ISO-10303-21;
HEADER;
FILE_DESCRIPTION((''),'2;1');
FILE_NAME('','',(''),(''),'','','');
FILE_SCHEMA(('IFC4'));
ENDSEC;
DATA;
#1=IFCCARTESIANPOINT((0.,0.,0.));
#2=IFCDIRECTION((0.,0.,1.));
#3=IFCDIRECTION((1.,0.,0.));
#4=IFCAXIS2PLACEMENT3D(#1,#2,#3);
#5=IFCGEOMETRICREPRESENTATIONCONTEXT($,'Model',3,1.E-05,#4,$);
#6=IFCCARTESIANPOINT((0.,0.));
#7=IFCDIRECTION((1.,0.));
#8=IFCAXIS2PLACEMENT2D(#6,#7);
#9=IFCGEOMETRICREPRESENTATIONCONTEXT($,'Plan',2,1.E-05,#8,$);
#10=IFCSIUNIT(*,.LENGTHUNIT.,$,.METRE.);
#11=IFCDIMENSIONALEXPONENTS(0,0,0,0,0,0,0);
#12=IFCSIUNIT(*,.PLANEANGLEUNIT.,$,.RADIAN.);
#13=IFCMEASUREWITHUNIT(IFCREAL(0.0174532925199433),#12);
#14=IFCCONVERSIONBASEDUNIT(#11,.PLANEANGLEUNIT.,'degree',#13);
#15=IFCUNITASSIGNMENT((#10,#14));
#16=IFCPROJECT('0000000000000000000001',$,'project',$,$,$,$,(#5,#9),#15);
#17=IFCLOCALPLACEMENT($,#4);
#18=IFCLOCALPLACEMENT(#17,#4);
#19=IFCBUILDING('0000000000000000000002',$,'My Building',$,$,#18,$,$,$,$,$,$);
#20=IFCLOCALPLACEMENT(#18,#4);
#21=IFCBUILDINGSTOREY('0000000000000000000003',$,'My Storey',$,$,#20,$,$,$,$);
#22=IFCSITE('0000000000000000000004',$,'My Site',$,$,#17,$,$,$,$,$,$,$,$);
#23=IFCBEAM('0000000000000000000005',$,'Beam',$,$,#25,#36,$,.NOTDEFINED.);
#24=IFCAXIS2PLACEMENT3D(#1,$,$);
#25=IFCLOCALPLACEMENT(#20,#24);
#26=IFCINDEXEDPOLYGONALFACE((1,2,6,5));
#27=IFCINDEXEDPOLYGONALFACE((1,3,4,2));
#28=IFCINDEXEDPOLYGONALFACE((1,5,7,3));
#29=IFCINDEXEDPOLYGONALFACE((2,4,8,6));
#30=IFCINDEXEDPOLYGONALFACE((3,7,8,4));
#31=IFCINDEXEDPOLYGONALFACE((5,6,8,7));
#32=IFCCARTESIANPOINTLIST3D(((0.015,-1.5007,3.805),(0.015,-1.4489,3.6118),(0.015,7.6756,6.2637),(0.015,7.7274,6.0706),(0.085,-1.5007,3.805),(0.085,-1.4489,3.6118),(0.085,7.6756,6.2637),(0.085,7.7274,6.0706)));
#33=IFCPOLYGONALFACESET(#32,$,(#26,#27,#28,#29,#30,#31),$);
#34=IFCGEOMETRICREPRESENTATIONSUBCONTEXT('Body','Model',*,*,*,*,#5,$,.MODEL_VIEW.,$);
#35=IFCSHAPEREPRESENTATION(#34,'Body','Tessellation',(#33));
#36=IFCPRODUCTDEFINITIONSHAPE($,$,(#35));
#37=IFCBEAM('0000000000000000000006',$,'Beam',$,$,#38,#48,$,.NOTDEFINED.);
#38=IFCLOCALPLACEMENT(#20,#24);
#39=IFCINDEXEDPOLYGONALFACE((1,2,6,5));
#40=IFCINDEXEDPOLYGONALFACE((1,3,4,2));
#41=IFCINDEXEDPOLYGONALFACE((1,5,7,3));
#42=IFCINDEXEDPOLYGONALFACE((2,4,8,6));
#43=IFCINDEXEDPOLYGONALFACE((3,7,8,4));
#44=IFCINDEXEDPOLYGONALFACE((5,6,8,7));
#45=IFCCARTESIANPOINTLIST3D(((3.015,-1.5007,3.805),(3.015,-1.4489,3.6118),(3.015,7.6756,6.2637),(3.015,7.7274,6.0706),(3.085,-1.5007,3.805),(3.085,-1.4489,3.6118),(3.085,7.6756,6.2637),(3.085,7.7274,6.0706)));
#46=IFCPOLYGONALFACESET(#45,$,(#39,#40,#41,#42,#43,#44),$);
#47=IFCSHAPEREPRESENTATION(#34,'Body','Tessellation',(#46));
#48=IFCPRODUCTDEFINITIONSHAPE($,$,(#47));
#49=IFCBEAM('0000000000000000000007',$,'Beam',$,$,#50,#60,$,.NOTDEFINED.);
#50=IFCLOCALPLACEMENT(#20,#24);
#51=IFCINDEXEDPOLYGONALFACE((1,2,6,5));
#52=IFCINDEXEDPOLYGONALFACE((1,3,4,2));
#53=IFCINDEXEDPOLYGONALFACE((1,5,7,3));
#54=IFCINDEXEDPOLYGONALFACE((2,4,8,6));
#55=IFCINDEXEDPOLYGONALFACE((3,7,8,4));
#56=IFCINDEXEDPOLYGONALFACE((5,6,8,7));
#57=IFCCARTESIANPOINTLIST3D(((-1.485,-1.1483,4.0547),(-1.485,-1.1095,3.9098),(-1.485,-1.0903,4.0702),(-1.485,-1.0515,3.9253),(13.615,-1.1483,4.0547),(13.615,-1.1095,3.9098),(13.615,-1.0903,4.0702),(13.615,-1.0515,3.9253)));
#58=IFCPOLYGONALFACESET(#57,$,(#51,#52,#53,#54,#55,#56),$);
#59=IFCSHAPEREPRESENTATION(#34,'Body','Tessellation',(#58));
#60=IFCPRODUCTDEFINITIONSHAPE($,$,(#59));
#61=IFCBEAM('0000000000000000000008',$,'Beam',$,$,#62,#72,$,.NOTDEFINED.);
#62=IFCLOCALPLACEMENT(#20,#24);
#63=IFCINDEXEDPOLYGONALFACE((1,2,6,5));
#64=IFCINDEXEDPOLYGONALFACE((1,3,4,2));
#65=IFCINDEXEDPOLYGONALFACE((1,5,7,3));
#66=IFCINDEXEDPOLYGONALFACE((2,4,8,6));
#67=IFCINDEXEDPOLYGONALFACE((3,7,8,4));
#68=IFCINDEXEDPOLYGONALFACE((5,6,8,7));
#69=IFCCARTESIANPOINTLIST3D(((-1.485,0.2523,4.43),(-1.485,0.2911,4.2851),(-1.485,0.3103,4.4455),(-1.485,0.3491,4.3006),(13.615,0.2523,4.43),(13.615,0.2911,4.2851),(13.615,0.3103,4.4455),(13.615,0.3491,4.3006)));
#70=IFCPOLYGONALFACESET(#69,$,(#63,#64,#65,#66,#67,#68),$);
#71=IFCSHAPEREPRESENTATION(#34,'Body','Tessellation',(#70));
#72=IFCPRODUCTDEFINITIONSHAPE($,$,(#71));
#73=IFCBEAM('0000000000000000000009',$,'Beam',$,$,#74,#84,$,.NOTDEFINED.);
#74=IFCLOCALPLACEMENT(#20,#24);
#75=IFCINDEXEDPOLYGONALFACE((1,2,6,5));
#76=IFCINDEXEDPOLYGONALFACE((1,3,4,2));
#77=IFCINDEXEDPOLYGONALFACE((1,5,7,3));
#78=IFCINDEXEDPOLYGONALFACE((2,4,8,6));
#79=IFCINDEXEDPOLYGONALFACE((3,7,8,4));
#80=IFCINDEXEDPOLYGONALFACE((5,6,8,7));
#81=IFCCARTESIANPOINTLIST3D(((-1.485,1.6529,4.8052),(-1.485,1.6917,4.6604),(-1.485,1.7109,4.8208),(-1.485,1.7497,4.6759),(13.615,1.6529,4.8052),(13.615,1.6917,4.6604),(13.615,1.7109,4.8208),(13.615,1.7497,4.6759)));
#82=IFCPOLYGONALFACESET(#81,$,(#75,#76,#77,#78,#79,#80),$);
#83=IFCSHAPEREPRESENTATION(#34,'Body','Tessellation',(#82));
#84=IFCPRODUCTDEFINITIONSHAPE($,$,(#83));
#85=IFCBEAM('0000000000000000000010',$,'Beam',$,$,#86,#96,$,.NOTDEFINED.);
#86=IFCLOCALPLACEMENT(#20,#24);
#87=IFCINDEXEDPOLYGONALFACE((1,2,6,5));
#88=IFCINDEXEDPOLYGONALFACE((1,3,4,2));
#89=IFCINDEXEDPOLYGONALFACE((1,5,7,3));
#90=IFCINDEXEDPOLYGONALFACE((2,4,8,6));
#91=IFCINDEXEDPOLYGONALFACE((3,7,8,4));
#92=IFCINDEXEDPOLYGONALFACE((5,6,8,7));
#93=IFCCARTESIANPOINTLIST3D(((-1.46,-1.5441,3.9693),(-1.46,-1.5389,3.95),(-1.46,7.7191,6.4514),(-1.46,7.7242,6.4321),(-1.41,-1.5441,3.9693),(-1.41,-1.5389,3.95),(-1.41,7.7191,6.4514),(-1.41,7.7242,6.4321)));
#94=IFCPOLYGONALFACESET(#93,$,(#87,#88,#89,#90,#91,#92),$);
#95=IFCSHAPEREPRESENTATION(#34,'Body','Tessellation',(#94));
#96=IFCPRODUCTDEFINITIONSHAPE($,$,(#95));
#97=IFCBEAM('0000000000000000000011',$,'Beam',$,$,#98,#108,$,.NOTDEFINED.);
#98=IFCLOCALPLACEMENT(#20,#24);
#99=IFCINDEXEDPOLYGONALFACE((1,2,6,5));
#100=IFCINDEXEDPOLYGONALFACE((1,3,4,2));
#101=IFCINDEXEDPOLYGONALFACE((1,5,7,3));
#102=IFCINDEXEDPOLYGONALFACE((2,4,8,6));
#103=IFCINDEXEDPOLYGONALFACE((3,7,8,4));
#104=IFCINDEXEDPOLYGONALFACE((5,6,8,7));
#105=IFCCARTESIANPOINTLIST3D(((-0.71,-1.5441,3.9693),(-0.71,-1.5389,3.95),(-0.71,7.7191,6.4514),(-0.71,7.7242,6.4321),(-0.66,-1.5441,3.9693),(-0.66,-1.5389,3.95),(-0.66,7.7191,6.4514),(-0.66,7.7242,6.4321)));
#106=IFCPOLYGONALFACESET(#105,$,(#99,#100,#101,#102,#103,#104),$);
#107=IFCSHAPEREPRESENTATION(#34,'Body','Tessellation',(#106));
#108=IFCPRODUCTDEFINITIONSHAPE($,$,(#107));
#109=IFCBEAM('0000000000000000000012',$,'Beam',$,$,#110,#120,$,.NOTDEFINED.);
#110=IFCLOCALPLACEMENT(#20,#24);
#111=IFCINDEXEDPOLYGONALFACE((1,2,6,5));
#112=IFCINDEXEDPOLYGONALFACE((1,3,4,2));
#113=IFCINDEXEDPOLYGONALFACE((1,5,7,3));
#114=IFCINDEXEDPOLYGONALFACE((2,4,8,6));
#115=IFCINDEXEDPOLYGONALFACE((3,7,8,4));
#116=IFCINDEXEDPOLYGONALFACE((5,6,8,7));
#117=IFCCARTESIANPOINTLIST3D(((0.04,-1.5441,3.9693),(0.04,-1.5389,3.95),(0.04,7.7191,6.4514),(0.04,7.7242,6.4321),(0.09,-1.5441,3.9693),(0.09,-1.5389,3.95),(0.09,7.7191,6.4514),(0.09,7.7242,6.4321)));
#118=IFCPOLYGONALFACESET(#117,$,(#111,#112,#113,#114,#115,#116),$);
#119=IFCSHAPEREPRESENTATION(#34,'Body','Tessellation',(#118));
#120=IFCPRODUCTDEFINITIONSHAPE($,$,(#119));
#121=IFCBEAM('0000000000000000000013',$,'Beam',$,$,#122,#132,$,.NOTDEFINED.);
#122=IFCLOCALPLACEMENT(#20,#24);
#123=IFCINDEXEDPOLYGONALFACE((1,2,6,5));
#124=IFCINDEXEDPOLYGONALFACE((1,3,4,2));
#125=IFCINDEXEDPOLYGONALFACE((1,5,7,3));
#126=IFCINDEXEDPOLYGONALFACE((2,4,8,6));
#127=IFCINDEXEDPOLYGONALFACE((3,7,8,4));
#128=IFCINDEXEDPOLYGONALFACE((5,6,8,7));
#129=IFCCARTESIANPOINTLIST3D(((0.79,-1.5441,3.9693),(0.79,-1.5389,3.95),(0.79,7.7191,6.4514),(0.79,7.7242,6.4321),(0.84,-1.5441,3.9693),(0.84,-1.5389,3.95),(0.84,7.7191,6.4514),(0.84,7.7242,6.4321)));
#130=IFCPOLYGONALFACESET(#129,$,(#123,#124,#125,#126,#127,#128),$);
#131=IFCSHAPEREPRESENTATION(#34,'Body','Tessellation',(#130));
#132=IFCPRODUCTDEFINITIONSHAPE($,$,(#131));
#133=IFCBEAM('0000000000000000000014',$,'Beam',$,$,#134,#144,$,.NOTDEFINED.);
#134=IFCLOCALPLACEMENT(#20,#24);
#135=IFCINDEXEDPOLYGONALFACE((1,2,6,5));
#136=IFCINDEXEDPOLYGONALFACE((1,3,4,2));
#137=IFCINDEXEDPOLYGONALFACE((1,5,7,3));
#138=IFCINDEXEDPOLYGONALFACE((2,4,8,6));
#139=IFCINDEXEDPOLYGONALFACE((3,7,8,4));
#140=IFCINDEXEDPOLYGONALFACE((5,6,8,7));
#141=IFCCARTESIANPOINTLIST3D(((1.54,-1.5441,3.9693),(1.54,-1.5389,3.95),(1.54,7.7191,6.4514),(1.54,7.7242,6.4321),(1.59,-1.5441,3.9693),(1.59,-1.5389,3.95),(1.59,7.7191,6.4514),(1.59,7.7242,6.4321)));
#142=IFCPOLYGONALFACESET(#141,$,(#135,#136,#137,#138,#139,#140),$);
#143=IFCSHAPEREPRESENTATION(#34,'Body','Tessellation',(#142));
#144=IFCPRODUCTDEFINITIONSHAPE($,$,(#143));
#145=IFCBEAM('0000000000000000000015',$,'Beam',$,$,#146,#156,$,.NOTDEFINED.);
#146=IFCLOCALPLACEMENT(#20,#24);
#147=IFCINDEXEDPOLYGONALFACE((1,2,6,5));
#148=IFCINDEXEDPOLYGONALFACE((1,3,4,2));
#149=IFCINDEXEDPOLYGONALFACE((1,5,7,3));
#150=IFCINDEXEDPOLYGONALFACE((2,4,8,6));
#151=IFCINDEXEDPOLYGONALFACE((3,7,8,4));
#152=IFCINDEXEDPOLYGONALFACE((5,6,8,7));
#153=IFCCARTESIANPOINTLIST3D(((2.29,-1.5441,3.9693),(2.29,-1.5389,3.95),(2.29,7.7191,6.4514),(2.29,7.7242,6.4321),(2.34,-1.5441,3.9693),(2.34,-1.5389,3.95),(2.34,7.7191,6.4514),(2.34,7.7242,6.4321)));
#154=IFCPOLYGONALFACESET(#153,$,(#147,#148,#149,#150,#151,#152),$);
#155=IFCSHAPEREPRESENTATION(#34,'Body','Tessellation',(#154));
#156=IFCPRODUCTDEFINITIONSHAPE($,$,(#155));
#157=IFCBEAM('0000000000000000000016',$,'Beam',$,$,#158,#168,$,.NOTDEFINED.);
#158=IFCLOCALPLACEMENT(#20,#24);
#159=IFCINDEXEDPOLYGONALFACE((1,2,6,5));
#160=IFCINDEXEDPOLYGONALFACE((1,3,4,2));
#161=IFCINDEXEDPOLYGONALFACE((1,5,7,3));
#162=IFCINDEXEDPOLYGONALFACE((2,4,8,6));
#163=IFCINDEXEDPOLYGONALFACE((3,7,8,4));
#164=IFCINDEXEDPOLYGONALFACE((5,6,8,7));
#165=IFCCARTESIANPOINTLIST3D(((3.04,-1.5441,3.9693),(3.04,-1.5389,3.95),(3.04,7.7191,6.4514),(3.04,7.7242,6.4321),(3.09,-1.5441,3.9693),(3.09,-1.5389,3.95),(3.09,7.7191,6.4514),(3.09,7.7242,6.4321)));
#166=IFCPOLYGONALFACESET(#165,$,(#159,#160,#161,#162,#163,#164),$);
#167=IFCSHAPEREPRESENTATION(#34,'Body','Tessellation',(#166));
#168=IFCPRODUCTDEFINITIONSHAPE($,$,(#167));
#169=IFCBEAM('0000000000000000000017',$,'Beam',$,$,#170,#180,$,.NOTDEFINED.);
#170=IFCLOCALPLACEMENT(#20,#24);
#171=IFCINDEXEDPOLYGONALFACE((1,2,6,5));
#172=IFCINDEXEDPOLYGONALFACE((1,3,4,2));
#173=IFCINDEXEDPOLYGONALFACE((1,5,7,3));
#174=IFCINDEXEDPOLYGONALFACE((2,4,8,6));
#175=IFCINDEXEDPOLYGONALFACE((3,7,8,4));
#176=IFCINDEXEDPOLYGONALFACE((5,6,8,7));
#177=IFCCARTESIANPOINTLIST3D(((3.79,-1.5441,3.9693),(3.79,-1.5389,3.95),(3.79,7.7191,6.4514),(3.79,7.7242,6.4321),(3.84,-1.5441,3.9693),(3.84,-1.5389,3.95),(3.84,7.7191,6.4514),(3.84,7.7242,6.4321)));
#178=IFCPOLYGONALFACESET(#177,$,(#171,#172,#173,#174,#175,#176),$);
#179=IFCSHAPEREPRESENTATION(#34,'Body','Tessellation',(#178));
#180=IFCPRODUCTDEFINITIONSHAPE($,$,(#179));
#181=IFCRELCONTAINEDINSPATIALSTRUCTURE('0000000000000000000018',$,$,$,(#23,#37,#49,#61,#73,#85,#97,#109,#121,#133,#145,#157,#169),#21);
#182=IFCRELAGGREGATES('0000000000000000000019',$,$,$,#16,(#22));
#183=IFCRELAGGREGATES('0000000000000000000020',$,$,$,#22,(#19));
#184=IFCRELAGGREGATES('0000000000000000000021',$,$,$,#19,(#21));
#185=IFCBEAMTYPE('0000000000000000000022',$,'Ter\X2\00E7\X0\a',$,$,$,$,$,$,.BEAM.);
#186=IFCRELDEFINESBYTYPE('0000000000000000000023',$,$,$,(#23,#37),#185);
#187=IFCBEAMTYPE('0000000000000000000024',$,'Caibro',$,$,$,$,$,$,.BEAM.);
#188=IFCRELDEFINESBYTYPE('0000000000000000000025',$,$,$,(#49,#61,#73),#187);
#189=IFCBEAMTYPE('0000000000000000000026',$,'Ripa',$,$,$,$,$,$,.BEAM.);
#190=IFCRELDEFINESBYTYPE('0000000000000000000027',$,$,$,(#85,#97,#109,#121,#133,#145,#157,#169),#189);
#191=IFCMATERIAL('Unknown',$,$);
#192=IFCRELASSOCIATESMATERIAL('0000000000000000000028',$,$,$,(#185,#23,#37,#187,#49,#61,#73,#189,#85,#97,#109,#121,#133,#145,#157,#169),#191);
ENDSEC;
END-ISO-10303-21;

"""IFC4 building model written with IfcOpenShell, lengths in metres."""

from ifc_helpers import new_model, entity, si_unit, converted_unit, frame, origin_with_axes, origin_2d_with_axis, place, context, subcontext, project, spatial, rectangle, extrude, material, material_profile, profile_set, profile_usage, type_object, element, save


model = new_model("IFC4")

# Units and contexts
model_context = context("Model", 3, precision=1e-05, world=origin_with_axes())
plan_context = context("Plan", 2, precision=1e-05, world=origin_2d_with_axis())
body_context = subcontext(model_context, "Body", "Model", "MODEL_VIEW")
ifc_project = project(units=[si_unit("LENGTHUNIT", "METRE"), converted_unit("PLANEANGLEUNIT", "degree", entity("IfcReal", 0.0174532925199433), si_unit("PLANEANGLEUNIT", "RADIAN"), dimensions=[0, 0, 0, 0, 0, 0, 0])], contexts=[model_context, plan_context])

# Site, building, storey
site_placement = place(None, origin_with_axes())
site = spatial("IfcSite", under=ifc_project, at=site_placement, Name="My Site")
building_placement = place(site_placement, origin_with_axes())
building = spatial("IfcBuilding", under=site, at=building_placement, Name="My Building")
storey_placement = place(building_placement, origin_with_axes())
storey = spatial("IfcBuildingStorey", under=building, at=storey_placement, Name="My Storey")

# Beams
ifc_material_1 = material(Name="Unknown")
ifc_material_profile_1 = material_profile(ifc_material_1, rectangle(XDim=0.07, YDim=0.2))
ifc_profile_set_1 = profile_set([ifc_material_profile_1])
ifc_profile_usage_1 = profile_usage(ifc_profile_set_1, cardinal=2)
beam_type_1 = type_object("IfcBeamType", Name="Terça", PredefinedType="BEAM", material=ifc_profile_set_1)
beam_1_placement = place(storey_placement, frame((0.05, -1.4489, 3.6118), z_axis=(0.0, 0.965926, 0.258819), x_axis=(-1.0, 0.0, 0.0)))
element("IfcBeam", 1, at=beam_1_placement, inside=storey, type_object=beam_type_1, material=ifc_profile_usage_1, Name="Beam", PredefinedType="NOTDEFINED", context=body_context, shape_type="SweptSolid", body=[
    extrude(rectangle(XDim=0.07, YDim=0.2), frame((0.0, 0.1, 0.0), z_axis=(0.0, 0.0, 1.0), x_axis=(1.0, 0.0, 0.0)), (0.0, 0.0, 1.0), 9.5),
])
ifc_profile_usage_2 = profile_usage(ifc_profile_set_1, cardinal=2)
beam_2_placement = place(storey_placement, frame((3.05, -1.4489, 3.6118), z_axis=(0.0, 0.965926, 0.258819), x_axis=(-1.0, 0.0, 0.0)))
element("IfcBeam", 2, at=beam_2_placement, inside=storey, type_object=beam_type_1, material=ifc_profile_usage_2, Name="Beam", PredefinedType="NOTDEFINED", context=body_context, shape_type="SweptSolid", body=[
    extrude(rectangle(XDim=0.07, YDim=0.2), frame((0.0, 0.1, 0.0), z_axis=(0.0, 0.0, 1.0), x_axis=(1.0, 0.0, 0.0)), (0.0, 0.0, 1.0), 9.5),
])
ifc_material_profile_2 = material_profile(ifc_material_1, rectangle(XDim=0.06, YDim=0.15))
ifc_profile_set_2 = profile_set([ifc_material_profile_2])
ifc_profile_usage_3 = profile_usage(ifc_profile_set_2, cardinal=2)
beam_type_2 = type_object("IfcBeamType", Name="Caibro", PredefinedType="BEAM", material=ifc_profile_set_2)
beam_3_placement = place(storey_placement, frame((-1.485, -1.0805, 3.9175), z_axis=(1.0, 0.0, 0.0), x_axis=(0.0, 0.965926, 0.25882)))
element("IfcBeam", 3, at=beam_3_placement, inside=storey, type_object=beam_type_2, material=ifc_profile_usage_3, Name="Beam", PredefinedType="NOTDEFINED", context=body_context, shape_type="SweptSolid", body=[
    extrude(rectangle(XDim=0.06, YDim=0.15), frame((0.0, 0.075, 0.0), z_axis=(0.0, 0.0, 1.0), x_axis=(1.0, 0.0, 0.0)), (0.0, 0.0, 1.0), 15.1),
])
ifc_profile_usage_4 = profile_usage(ifc_profile_set_2, cardinal=2)
beam_4_placement = place(storey_placement, frame((-1.485, 0.3201, 4.2928), z_axis=(1.0, 0.0, 0.0), x_axis=(0.0, 0.965926, 0.25882)))
element("IfcBeam", 4, at=beam_4_placement, inside=storey, type_object=beam_type_2, material=ifc_profile_usage_4, Name="Beam", PredefinedType="NOTDEFINED", context=body_context, shape_type="SweptSolid", body=[
    extrude(rectangle(XDim=0.06, YDim=0.15), frame((0.0, 0.075, 0.0), z_axis=(0.0, 0.0, 1.0), x_axis=(1.0, 0.0, 0.0)), (0.0, 0.0, 1.0), 15.1),
])
ifc_profile_usage_5 = profile_usage(ifc_profile_set_2, cardinal=2)
beam_5_placement = place(storey_placement, frame((-1.485, 1.7207, 4.6681), z_axis=(1.0, 0.0, 0.0), x_axis=(0.0, 0.965926, 0.25882)))
element("IfcBeam", 5, at=beam_5_placement, inside=storey, type_object=beam_type_2, material=ifc_profile_usage_5, Name="Beam", PredefinedType="NOTDEFINED", context=body_context, shape_type="SweptSolid", body=[
    extrude(rectangle(XDim=0.06, YDim=0.15), frame((0.0, 0.075, 0.0), z_axis=(0.0, 0.0, 1.0), x_axis=(1.0, 0.0, 0.0)), (0.0, 0.0, 1.0), 15.1),
])
ifc_material_profile_3 = material_profile(ifc_material_1, rectangle(XDim=0.05, YDim=0.02))
ifc_profile_set_3 = profile_set([ifc_material_profile_3])
ifc_profile_usage_6 = profile_usage(ifc_profile_set_3, cardinal=2)
beam_type_3 = type_object("IfcBeamType", Name="Ripa", PredefinedType="BEAM", material=ifc_profile_set_3)
beam_6_placement = place(storey_placement, frame((-1.435, -1.5389, 3.95), z_axis=(-0.000001, 0.965926, 0.25882), x_axis=(-1.0, -0.000001, 0.0)))
element("IfcBeam", 6, at=beam_6_placement, inside=storey, type_object=beam_type_3, material=ifc_profile_usage_6, Name="Beam", PredefinedType="NOTDEFINED", context=body_context, shape_type="SweptSolid", body=[
    extrude(rectangle(XDim=0.05, YDim=0.02), frame((0.0, 0.01, 0.0), z_axis=(0.0, 0.0, 1.0), x_axis=(1.0, 0.0, 0.0)), (0.0, 0.0, 1.0), 9.5899),
])
ifc_profile_usage_7 = profile_usage(ifc_profile_set_3, cardinal=2)
beam_7_placement = place(storey_placement, frame((-0.685, -1.5389, 3.95), z_axis=(-0.000001, 0.965926, 0.25882), x_axis=(-1.0, -0.000001, 0.0)))
element("IfcBeam", 7, at=beam_7_placement, inside=storey, type_object=beam_type_3, material=ifc_profile_usage_7, Name="Beam", PredefinedType="NOTDEFINED", context=body_context, shape_type="SweptSolid", body=[
    extrude(rectangle(XDim=0.05, YDim=0.02), frame((0.0, 0.01, 0.0), z_axis=(0.0, 0.0, 1.0), x_axis=(1.0, 0.0, 0.0)), (0.0, 0.0, 1.0), 9.5899),
])
ifc_profile_usage_8 = profile_usage(ifc_profile_set_3, cardinal=2)
beam_8_placement = place(storey_placement, frame((0.065, -1.5389, 3.95), z_axis=(-0.000001, 0.965926, 0.25882), x_axis=(-1.0, -0.000001, 0.0)))
element("IfcBeam", 8, at=beam_8_placement, inside=storey, type_object=beam_type_3, material=ifc_profile_usage_8, Name="Beam", PredefinedType="NOTDEFINED", context=body_context, shape_type="SweptSolid", body=[
    extrude(rectangle(XDim=0.05, YDim=0.02), frame((0.0, 0.01, 0.0), z_axis=(0.0, 0.0, 1.0), x_axis=(1.0, 0.0, 0.0)), (0.0, 0.0, 1.0), 9.5899),
])
ifc_profile_usage_9 = profile_usage(ifc_profile_set_3, cardinal=2)
beam_9_placement = place(storey_placement, frame((0.815, -1.5389, 3.95), z_axis=(-0.000001, 0.965926, 0.25882), x_axis=(-1.0, -0.000001, 0.0)))
element("IfcBeam", 9, at=beam_9_placement, inside=storey, type_object=beam_type_3, material=ifc_profile_usage_9, Name="Beam", PredefinedType="NOTDEFINED", context=body_context, shape_type="SweptSolid", body=[
    extrude(rectangle(XDim=0.05, YDim=0.02), frame((0.0, 0.01, 0.0), z_axis=(0.0, 0.0, 1.0), x_axis=(1.0, 0.0, 0.0)), (0.0, 0.0, 1.0), 9.5899),
])
ifc_profile_usage_10 = profile_usage(ifc_profile_set_3, cardinal=2)
beam_10_placement = place(storey_placement, frame((1.565, -1.5389, 3.95), z_axis=(-0.000001, 0.965926, 0.25882), x_axis=(-1.0, -0.000001, 0.0)))
element("IfcBeam", 10, at=beam_10_placement, inside=storey, type_object=beam_type_3, material=ifc_profile_usage_10, Name="Beam", PredefinedType="NOTDEFINED", context=body_context, shape_type="SweptSolid", body=[
    extrude(rectangle(XDim=0.05, YDim=0.02), frame((0.0, 0.01, 0.0), z_axis=(0.0, 0.0, 1.0), x_axis=(1.0, 0.0, 0.0)), (0.0, 0.0, 1.0), 9.5899),
])
ifc_profile_usage_11 = profile_usage(ifc_profile_set_3, cardinal=2)
beam_11_placement = place(storey_placement, frame((2.315, -1.5389, 3.95), z_axis=(-0.000001, 0.965926, 0.25882), x_axis=(-1.0, -0.000001, 0.0)))
element("IfcBeam", 11, at=beam_11_placement, inside=storey, type_object=beam_type_3, material=ifc_profile_usage_11, Name="Beam", PredefinedType="NOTDEFINED", context=body_context, shape_type="SweptSolid", body=[
    extrude(rectangle(XDim=0.05, YDim=0.02), frame((0.0, 0.01, 0.0), z_axis=(0.0, 0.0, 1.0), x_axis=(1.0, 0.0, 0.0)), (0.0, 0.0, 1.0), 9.5899),
])
ifc_profile_usage_12 = profile_usage(ifc_profile_set_3, cardinal=2)
beam_12_placement = place(storey_placement, frame((3.065, -1.5389, 3.95), z_axis=(-0.000001, 0.965926, 0.25882), x_axis=(-1.0, -0.000001, 0.0)))
element("IfcBeam", 12, at=beam_12_placement, inside=storey, type_object=beam_type_3, material=ifc_profile_usage_12, Name="Beam", PredefinedType="NOTDEFINED", context=body_context, shape_type="SweptSolid", body=[
    extrude(rectangle(XDim=0.05, YDim=0.02), frame((0.0, 0.01, 0.0), z_axis=(0.0, 0.0, 1.0), x_axis=(1.0, 0.0, 0.0)), (0.0, 0.0, 1.0), 9.5899),
])
ifc_profile_usage_13 = profile_usage(ifc_profile_set_3, cardinal=2)
beam_13_placement = place(storey_placement, frame((3.815, -1.5389, 3.95), z_axis=(-0.000001, 0.965926, 0.25882), x_axis=(-1.0, -0.000001, 0.0)))
element("IfcBeam", 13, at=beam_13_placement, inside=storey, type_object=beam_type_3, material=ifc_profile_usage_13, Name="Beam", PredefinedType="NOTDEFINED", context=body_context, shape_type="SweptSolid", body=[
    extrude(rectangle(XDim=0.05, YDim=0.02), frame((0.0, 0.01, 0.0), z_axis=(0.0, 0.0, 1.0), x_axis=(1.0, 0.0, 0.0)), (0.0, 0.0, 1.0), 9.5899),
])

save(model, "model.ifc")
